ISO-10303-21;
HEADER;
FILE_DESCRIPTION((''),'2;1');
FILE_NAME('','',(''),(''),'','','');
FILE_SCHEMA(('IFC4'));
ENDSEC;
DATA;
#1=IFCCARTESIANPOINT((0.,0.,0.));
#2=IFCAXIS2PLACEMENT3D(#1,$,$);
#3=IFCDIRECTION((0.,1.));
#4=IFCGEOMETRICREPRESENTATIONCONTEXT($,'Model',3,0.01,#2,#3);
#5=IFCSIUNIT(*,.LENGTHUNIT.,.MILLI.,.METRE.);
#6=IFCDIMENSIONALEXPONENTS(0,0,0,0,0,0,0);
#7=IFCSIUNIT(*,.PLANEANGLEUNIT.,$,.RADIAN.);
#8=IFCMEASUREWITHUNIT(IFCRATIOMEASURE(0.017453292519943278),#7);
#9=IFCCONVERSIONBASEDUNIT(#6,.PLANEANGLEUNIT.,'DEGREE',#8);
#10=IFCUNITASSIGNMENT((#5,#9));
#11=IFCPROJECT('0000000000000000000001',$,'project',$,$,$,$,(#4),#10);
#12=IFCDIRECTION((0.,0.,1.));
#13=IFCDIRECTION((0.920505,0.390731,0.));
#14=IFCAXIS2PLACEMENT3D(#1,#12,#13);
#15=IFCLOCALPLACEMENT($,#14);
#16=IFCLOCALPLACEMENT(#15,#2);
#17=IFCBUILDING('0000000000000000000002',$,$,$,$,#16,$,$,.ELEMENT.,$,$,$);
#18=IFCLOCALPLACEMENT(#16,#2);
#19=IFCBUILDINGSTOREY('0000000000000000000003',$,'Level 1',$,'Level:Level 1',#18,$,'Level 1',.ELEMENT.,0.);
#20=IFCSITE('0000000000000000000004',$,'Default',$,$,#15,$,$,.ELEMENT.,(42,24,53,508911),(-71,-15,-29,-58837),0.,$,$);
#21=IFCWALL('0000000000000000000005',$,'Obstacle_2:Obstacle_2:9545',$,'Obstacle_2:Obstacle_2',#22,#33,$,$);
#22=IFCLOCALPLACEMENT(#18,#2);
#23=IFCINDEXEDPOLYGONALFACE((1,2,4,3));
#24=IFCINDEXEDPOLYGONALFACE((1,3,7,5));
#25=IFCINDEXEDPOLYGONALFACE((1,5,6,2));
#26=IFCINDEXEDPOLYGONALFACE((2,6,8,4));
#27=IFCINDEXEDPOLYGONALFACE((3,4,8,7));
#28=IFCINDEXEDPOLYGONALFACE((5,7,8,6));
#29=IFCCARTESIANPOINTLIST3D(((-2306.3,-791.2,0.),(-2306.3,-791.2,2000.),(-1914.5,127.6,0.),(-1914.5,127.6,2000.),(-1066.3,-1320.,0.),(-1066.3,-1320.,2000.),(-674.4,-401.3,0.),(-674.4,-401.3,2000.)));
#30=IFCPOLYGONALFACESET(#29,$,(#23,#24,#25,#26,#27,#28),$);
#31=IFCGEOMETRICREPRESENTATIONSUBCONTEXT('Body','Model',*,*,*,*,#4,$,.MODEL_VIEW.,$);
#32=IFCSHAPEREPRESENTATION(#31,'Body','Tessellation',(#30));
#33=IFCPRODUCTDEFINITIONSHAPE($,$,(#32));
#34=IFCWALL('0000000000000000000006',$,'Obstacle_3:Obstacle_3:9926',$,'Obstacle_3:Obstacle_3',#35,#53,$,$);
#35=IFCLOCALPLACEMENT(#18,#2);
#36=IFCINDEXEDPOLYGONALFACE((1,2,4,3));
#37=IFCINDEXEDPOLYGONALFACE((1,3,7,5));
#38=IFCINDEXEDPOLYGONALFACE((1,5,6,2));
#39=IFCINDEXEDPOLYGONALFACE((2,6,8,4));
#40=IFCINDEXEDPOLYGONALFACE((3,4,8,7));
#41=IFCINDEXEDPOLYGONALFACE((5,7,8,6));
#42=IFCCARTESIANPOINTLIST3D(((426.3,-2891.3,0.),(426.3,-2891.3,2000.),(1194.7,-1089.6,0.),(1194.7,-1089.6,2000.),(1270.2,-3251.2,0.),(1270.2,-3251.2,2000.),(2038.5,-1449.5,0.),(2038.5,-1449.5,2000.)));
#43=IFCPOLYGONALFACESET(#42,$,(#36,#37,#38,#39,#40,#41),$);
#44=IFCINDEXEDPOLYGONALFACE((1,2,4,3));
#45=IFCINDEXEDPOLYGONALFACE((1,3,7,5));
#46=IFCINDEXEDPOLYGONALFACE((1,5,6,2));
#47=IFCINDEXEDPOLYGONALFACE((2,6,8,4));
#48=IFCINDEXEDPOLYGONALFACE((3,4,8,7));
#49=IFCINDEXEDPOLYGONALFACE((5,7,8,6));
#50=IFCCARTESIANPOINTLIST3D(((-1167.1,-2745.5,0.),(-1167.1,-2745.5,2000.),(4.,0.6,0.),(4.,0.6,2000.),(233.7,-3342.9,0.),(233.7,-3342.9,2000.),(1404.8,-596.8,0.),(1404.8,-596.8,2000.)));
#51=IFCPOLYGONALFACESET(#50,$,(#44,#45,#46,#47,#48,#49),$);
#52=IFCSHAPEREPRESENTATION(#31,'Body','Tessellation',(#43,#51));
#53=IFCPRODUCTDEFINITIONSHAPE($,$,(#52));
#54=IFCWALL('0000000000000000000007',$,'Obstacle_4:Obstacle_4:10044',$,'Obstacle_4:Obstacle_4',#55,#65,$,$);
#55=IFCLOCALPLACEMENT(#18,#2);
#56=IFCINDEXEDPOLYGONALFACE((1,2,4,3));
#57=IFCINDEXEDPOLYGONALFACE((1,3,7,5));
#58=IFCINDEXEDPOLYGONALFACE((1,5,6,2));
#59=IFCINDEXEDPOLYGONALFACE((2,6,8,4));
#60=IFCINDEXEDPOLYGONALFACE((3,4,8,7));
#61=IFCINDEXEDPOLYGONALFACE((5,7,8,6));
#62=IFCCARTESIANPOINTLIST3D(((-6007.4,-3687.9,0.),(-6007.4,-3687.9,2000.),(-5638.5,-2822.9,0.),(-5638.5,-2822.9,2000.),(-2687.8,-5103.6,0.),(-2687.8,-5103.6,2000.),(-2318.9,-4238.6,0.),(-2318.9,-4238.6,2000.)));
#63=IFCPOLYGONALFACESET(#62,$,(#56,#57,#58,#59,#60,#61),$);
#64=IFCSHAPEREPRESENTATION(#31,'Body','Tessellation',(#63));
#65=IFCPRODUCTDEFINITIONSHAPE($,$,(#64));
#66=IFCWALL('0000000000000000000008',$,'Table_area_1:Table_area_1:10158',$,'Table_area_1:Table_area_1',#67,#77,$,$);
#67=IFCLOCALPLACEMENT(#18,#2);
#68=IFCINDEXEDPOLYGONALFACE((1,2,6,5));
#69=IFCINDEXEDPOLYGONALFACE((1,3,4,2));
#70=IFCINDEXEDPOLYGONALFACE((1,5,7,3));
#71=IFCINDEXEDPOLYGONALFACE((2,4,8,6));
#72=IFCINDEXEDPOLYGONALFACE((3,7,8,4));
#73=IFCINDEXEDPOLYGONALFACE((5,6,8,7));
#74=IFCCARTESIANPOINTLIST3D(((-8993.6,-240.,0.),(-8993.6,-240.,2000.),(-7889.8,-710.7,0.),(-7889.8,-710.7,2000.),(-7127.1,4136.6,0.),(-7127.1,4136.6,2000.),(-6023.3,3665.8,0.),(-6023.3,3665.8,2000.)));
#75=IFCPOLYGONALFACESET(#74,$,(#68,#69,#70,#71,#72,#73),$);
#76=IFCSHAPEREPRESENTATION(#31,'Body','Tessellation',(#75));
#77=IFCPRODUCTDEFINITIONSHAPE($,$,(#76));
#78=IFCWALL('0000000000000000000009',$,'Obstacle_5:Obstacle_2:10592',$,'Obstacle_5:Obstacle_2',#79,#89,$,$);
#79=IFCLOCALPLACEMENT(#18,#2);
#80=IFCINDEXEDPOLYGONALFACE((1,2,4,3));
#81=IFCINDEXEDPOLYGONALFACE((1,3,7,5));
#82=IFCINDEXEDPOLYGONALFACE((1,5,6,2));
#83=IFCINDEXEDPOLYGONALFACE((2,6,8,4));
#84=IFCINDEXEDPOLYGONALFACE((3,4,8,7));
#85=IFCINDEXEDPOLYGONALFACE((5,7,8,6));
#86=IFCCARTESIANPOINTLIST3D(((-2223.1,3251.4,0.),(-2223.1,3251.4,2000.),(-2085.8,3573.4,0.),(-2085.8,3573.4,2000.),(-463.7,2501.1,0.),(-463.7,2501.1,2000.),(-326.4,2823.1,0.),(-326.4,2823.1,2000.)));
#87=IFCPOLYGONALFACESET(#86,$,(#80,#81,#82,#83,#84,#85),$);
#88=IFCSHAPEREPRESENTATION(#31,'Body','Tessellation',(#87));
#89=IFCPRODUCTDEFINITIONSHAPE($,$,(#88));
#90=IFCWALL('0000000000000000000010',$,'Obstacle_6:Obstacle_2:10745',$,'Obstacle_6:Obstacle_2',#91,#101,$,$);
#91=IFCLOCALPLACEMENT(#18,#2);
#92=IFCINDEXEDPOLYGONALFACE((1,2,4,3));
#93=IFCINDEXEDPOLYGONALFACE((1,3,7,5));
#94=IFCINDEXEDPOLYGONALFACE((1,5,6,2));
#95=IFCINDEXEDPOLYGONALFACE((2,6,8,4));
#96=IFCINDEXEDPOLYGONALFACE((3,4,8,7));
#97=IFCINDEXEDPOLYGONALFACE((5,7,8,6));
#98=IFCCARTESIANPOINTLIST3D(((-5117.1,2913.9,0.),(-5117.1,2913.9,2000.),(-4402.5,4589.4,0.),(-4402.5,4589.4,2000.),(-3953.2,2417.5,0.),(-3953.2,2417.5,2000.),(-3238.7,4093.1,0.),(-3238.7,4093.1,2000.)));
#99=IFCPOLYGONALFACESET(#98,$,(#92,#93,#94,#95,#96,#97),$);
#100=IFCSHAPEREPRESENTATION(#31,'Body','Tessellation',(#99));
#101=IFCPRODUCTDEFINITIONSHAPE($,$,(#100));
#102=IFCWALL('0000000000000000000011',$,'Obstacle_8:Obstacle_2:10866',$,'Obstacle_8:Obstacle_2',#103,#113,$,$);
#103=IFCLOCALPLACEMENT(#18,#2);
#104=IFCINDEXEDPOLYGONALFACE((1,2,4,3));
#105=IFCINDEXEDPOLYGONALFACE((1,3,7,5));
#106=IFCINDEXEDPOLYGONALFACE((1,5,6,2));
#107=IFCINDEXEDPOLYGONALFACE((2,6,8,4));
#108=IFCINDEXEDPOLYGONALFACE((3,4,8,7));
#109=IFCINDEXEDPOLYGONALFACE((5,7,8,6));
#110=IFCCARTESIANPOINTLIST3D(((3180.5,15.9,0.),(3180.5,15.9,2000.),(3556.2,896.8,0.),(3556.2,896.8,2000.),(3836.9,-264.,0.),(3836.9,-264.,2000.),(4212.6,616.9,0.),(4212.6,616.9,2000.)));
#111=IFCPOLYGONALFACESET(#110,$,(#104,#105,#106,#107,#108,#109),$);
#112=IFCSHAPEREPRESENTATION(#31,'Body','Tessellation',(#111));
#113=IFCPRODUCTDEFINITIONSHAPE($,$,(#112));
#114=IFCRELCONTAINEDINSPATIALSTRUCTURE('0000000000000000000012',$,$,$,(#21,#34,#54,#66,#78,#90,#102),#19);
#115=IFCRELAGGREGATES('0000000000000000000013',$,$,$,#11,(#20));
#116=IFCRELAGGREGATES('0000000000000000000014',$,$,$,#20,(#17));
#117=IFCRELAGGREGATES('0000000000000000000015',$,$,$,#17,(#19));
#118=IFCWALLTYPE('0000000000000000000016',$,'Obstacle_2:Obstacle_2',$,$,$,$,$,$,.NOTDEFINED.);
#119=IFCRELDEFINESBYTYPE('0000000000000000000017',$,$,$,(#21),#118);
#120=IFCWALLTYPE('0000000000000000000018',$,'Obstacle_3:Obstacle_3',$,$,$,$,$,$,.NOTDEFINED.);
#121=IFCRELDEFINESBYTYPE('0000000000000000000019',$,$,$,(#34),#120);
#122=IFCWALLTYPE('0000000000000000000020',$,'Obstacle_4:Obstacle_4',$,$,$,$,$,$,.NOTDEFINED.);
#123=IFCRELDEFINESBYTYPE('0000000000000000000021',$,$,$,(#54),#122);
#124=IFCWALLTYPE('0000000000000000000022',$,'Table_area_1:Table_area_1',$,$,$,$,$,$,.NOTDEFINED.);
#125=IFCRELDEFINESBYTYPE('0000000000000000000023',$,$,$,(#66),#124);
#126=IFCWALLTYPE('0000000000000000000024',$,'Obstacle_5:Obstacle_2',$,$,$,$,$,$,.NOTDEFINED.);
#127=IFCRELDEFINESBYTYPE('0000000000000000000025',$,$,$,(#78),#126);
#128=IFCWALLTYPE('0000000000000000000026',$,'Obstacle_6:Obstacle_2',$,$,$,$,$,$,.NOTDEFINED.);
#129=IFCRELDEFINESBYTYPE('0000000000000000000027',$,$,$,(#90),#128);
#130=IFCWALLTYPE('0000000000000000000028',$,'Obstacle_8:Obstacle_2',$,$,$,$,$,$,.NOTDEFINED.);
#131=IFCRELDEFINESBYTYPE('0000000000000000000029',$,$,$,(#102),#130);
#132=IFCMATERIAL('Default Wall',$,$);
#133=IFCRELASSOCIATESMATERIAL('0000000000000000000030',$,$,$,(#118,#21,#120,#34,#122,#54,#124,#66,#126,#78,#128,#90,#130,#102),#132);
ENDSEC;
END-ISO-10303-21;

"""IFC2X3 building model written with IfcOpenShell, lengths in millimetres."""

from ifc_helpers import new_model, entity, si_unit, converted_unit, direction, frame, frame_2d, origin, origin_2d_with_axis, place, context, subcontext, project, spatial, rectangle, extrude, material, type_object, element, save


model = new_model("IFC2X3")

# Units and contexts
model_context = context("Model", 3, precision=0.01, world=origin(), true_north=direction((0.0, 1.0)))
body_context = subcontext(model_context, "Body", "Model", "MODEL_VIEW")
ifc_project = project(units=[si_unit("LENGTHUNIT", "METRE", prefix="MILLI"), converted_unit("PLANEANGLEUNIT", "DEGREE", entity("IfcRatioMeasure", 0.017453292519943278), si_unit("PLANEANGLEUNIT", "RADIAN"), dimensions=[0, 0, 0, 0, 0, 0, 0])], contexts=[model_context])

# Site, building, storey
site_placement = place(None, frame((0.0, 0.0, 0.0), z_axis=(0.0, 0.0, 1.0), x_axis=(0.920505, 0.390731, 0.0)))
site = spatial("IfcSite", under=ifc_project, at=site_placement, Name="Default", CompositionType="ELEMENT", RefLatitude=(42, 24, 53, 508911), RefLongitude=(-71, -15, -29, -58837), RefElevation=0.0)
building_placement = place(site_placement, origin())
building = spatial("IfcBuilding", under=site, at=building_placement, CompositionType="ELEMENT")
storey_placement = place(building_placement, origin())
storey = spatial("IfcBuildingStorey", under=building, at=storey_placement, Name="Level 1", ObjectType="Level:Level 1", LongName="Level 1", CompositionType="ELEMENT", Elevation=0.0)

# Walls
ifc_material_1 = material(Name="Default Wall")
wall_type_1 = type_object("IfcWallType", Name="Obstacle_2:Obstacle_2", PredefinedType="NOTDEFINED", material=ifc_material_1)
wall_1_placement = place(storey_placement, frame((-2306.3, -791.2, 0.0), z_axis=(0.0, 0.0, 1.0), x_axis=(0.919844, -0.392284, 0.0)))
element("IfcWall", 1, at=wall_1_placement, inside=storey, type_object=wall_type_1, material=ifc_material_1, Name="Obstacle_2:Obstacle_2:9545", ObjectType="Obstacle_2:Obstacle_2", context=body_context, shape_type="SweptSolid", body=[
    extrude(rectangle(XDim=1348.1, YDim=998.8, at=frame_2d((0.0, 0.0), x_axis=(1.0, 0.0))), frame((674.0, 499.4, 0.0), z_axis=(0.0, 0.0, 1.0), x_axis=(-1.0, 0.0, 0.0)), (0.0, 0.0, 1.0), 2000.0),
])
wall_type_2 = type_object("IfcWallType", Name="Obstacle_3:Obstacle_3", PredefinedType="NOTDEFINED", material=ifc_material_1)
wall_2_placement = place(storey_placement, frame((-1167.1, -2745.5, 0.0), z_axis=(0.0, 0.0, 1.0), x_axis=(0.392284, 0.919844, 0.0)))
element("IfcWall", 2, at=wall_2_placement, inside=storey, type_object=wall_type_2, material=ifc_material_1, Name="Obstacle_3:Obstacle_3:9926", ObjectType="Obstacle_3:Obstacle_3", context=body_context, shape_type="SweptSolid", body=[
    extrude(rectangle(XDim=1958.7, YDim=917.4, at=frame_2d((0.0, 0.0), x_axis=(1.0, 0.0))), frame((1470.3, -1981.6, 0.0), z_axis=(0.0, 0.0, 1.0), x_axis=(-1.0, 0.0, 0.0)), (0.0, 0.0, 1.0), 2000.0),
    extrude(rectangle(XDim=1522.9, YDim=2985.4, at=frame_2d((0.0, 0.0), x_axis=(1.0, 0.0))), frame((1492.7, -761.4, 0.0), z_axis=(0.0, 0.0, 1.0), x_axis=(0.0, 1.0, 0.0)), (0.0, 0.0, 1.0), 2000.0),
])
wall_type_3 = type_object("IfcWallType", Name="Obstacle_4:Obstacle_4", PredefinedType="NOTDEFINED", material=ifc_material_1)
wall_3_placement = place(storey_placement, frame((-6007.4, -3687.9, 0.0), z_axis=(0.0, 0.0, 1.0), x_axis=(0.919844, -0.392284, 0.0)))
element("IfcWall", 3, at=wall_3_placement, inside=storey, type_object=wall_type_3, material=ifc_material_1, Name="Obstacle_4:Obstacle_4:10044", ObjectType="Obstacle_4:Obstacle_4", context=body_context, shape_type="SweptSolid", body=[
    extrude(rectangle(XDim=3608.8, YDim=940.4, at=frame_2d((0.0, 0.0), x_axis=(1.0, 0.0))), frame((1804.4, 470.2, 0.0), z_axis=(0.0, 0.0, 1.0), x_axis=(-1.0, 0.0, 0.0)), (0.0, 0.0, 1.0), 2000.0),
])
wall_type_4 = type_object("IfcWallType", Name="Table_area_1:Table_area_1", PredefinedType="NOTDEFINED", material=ifc_material_1)
wall_4_placement = place(storey_placement, frame((-8993.6, -240.0, 0.0), z_axis=(0.0, 0.0, 1.0), x_axis=(0.392284, 0.919844, 0.0)))
element("IfcWall", 4, at=wall_4_placement, inside=storey, type_object=wall_type_4, material=ifc_material_1, Name="Table_area_1:Table_area_1:10158", ObjectType="Table_area_1:Table_area_1", context=body_context, shape_type="SweptSolid", body=[
    extrude(rectangle(XDim=1200.0, YDim=4757.9, at=frame_2d((0.0, 0.0), x_axis=(1.0, 0.0))), frame((2379.0, -600.0, 0.0), z_axis=(0.0, 0.0, 1.0), x_axis=(0.0, 1.0, 0.0)), (0.0, 0.0, 1.0), 2000.0),
])
wall_type_5 = type_object("IfcWallType", Name="Obstacle_5:Obstacle_2", PredefinedType="NOTDEFINED", material=ifc_material_1)
wall_5_placement = place(storey_placement, frame((-2223.1, 3251.4, 0.0), z_axis=(0.0, 0.0, 1.0), x_axis=(0.919844, -0.392284, 0.0)))
element("IfcWall", 5, at=wall_5_placement, inside=storey, type_object=wall_type_5, material=ifc_material_1, Name="Obstacle_5:Obstacle_2:10592", ObjectType="Obstacle_5:Obstacle_2", context=body_context, shape_type="SweptSolid", body=[
    extrude(rectangle(XDim=1912.7, YDim=350.0, at=frame_2d((0.0, 0.0), x_axis=(1.0, 0.0))), frame((956.4, 175.0, 0.0), z_axis=(0.0, 0.0, 1.0), x_axis=(-1.0, 0.0, 0.0)), (0.0, 0.0, 1.0), 2000.0),
])
wall_type_6 = type_object("IfcWallType", Name="Obstacle_6:Obstacle_2", PredefinedType="NOTDEFINED", material=ifc_material_1)
wall_6_placement = place(storey_placement, frame((-5117.1, 2913.9, 0.0), z_axis=(0.0, 0.0, 1.0), x_axis=(0.392284, 0.919844, 0.0)))
element("IfcWall", 6, at=wall_6_placement, inside=storey, type_object=wall_type_6, material=ifc_material_1, Name="Obstacle_6:Obstacle_2:10745", ObjectType="Obstacle_6:Obstacle_2", context=body_context, shape_type="SweptSolid", body=[
    extrude(rectangle(XDim=1265.3, YDim=1821.6, at=frame_2d((0.0, 0.0), x_axis=(1.0, 0.0))), frame((910.8, -632.7, 0.0), z_axis=(0.0, 0.0, 1.0), x_axis=(0.0, 1.0, 0.0)), (0.0, 0.0, 1.0), 2000.0),
])
wall_type_7 = type_object("IfcWallType", Name="Obstacle_8:Obstacle_2", PredefinedType="NOTDEFINED", material=ifc_material_1)
wall_7_placement = place(storey_placement, frame((3180.5, 15.9, 0.0), z_axis=(0.0, 0.0, 1.0), x_axis=(0.392284, 0.919844, 0.0)))
element("IfcWall", 7, at=wall_7_placement, inside=storey, type_object=wall_type_7, material=ifc_material_1, Name="Obstacle_8:Obstacle_2:10866", ObjectType="Obstacle_8:Obstacle_2", context=body_context, shape_type="SweptSolid", body=[
    extrude(rectangle(XDim=713.5, YDim=957.7, at=origin_2d_with_axis()), frame((478.9, -356.8, 0.0), z_axis=(0.0, 0.0, 1.0), x_axis=(0.0, 1.0, 0.0)), (0.0, 0.0, 1.0), 2000.0),
])

save(model, "model.ifc")
